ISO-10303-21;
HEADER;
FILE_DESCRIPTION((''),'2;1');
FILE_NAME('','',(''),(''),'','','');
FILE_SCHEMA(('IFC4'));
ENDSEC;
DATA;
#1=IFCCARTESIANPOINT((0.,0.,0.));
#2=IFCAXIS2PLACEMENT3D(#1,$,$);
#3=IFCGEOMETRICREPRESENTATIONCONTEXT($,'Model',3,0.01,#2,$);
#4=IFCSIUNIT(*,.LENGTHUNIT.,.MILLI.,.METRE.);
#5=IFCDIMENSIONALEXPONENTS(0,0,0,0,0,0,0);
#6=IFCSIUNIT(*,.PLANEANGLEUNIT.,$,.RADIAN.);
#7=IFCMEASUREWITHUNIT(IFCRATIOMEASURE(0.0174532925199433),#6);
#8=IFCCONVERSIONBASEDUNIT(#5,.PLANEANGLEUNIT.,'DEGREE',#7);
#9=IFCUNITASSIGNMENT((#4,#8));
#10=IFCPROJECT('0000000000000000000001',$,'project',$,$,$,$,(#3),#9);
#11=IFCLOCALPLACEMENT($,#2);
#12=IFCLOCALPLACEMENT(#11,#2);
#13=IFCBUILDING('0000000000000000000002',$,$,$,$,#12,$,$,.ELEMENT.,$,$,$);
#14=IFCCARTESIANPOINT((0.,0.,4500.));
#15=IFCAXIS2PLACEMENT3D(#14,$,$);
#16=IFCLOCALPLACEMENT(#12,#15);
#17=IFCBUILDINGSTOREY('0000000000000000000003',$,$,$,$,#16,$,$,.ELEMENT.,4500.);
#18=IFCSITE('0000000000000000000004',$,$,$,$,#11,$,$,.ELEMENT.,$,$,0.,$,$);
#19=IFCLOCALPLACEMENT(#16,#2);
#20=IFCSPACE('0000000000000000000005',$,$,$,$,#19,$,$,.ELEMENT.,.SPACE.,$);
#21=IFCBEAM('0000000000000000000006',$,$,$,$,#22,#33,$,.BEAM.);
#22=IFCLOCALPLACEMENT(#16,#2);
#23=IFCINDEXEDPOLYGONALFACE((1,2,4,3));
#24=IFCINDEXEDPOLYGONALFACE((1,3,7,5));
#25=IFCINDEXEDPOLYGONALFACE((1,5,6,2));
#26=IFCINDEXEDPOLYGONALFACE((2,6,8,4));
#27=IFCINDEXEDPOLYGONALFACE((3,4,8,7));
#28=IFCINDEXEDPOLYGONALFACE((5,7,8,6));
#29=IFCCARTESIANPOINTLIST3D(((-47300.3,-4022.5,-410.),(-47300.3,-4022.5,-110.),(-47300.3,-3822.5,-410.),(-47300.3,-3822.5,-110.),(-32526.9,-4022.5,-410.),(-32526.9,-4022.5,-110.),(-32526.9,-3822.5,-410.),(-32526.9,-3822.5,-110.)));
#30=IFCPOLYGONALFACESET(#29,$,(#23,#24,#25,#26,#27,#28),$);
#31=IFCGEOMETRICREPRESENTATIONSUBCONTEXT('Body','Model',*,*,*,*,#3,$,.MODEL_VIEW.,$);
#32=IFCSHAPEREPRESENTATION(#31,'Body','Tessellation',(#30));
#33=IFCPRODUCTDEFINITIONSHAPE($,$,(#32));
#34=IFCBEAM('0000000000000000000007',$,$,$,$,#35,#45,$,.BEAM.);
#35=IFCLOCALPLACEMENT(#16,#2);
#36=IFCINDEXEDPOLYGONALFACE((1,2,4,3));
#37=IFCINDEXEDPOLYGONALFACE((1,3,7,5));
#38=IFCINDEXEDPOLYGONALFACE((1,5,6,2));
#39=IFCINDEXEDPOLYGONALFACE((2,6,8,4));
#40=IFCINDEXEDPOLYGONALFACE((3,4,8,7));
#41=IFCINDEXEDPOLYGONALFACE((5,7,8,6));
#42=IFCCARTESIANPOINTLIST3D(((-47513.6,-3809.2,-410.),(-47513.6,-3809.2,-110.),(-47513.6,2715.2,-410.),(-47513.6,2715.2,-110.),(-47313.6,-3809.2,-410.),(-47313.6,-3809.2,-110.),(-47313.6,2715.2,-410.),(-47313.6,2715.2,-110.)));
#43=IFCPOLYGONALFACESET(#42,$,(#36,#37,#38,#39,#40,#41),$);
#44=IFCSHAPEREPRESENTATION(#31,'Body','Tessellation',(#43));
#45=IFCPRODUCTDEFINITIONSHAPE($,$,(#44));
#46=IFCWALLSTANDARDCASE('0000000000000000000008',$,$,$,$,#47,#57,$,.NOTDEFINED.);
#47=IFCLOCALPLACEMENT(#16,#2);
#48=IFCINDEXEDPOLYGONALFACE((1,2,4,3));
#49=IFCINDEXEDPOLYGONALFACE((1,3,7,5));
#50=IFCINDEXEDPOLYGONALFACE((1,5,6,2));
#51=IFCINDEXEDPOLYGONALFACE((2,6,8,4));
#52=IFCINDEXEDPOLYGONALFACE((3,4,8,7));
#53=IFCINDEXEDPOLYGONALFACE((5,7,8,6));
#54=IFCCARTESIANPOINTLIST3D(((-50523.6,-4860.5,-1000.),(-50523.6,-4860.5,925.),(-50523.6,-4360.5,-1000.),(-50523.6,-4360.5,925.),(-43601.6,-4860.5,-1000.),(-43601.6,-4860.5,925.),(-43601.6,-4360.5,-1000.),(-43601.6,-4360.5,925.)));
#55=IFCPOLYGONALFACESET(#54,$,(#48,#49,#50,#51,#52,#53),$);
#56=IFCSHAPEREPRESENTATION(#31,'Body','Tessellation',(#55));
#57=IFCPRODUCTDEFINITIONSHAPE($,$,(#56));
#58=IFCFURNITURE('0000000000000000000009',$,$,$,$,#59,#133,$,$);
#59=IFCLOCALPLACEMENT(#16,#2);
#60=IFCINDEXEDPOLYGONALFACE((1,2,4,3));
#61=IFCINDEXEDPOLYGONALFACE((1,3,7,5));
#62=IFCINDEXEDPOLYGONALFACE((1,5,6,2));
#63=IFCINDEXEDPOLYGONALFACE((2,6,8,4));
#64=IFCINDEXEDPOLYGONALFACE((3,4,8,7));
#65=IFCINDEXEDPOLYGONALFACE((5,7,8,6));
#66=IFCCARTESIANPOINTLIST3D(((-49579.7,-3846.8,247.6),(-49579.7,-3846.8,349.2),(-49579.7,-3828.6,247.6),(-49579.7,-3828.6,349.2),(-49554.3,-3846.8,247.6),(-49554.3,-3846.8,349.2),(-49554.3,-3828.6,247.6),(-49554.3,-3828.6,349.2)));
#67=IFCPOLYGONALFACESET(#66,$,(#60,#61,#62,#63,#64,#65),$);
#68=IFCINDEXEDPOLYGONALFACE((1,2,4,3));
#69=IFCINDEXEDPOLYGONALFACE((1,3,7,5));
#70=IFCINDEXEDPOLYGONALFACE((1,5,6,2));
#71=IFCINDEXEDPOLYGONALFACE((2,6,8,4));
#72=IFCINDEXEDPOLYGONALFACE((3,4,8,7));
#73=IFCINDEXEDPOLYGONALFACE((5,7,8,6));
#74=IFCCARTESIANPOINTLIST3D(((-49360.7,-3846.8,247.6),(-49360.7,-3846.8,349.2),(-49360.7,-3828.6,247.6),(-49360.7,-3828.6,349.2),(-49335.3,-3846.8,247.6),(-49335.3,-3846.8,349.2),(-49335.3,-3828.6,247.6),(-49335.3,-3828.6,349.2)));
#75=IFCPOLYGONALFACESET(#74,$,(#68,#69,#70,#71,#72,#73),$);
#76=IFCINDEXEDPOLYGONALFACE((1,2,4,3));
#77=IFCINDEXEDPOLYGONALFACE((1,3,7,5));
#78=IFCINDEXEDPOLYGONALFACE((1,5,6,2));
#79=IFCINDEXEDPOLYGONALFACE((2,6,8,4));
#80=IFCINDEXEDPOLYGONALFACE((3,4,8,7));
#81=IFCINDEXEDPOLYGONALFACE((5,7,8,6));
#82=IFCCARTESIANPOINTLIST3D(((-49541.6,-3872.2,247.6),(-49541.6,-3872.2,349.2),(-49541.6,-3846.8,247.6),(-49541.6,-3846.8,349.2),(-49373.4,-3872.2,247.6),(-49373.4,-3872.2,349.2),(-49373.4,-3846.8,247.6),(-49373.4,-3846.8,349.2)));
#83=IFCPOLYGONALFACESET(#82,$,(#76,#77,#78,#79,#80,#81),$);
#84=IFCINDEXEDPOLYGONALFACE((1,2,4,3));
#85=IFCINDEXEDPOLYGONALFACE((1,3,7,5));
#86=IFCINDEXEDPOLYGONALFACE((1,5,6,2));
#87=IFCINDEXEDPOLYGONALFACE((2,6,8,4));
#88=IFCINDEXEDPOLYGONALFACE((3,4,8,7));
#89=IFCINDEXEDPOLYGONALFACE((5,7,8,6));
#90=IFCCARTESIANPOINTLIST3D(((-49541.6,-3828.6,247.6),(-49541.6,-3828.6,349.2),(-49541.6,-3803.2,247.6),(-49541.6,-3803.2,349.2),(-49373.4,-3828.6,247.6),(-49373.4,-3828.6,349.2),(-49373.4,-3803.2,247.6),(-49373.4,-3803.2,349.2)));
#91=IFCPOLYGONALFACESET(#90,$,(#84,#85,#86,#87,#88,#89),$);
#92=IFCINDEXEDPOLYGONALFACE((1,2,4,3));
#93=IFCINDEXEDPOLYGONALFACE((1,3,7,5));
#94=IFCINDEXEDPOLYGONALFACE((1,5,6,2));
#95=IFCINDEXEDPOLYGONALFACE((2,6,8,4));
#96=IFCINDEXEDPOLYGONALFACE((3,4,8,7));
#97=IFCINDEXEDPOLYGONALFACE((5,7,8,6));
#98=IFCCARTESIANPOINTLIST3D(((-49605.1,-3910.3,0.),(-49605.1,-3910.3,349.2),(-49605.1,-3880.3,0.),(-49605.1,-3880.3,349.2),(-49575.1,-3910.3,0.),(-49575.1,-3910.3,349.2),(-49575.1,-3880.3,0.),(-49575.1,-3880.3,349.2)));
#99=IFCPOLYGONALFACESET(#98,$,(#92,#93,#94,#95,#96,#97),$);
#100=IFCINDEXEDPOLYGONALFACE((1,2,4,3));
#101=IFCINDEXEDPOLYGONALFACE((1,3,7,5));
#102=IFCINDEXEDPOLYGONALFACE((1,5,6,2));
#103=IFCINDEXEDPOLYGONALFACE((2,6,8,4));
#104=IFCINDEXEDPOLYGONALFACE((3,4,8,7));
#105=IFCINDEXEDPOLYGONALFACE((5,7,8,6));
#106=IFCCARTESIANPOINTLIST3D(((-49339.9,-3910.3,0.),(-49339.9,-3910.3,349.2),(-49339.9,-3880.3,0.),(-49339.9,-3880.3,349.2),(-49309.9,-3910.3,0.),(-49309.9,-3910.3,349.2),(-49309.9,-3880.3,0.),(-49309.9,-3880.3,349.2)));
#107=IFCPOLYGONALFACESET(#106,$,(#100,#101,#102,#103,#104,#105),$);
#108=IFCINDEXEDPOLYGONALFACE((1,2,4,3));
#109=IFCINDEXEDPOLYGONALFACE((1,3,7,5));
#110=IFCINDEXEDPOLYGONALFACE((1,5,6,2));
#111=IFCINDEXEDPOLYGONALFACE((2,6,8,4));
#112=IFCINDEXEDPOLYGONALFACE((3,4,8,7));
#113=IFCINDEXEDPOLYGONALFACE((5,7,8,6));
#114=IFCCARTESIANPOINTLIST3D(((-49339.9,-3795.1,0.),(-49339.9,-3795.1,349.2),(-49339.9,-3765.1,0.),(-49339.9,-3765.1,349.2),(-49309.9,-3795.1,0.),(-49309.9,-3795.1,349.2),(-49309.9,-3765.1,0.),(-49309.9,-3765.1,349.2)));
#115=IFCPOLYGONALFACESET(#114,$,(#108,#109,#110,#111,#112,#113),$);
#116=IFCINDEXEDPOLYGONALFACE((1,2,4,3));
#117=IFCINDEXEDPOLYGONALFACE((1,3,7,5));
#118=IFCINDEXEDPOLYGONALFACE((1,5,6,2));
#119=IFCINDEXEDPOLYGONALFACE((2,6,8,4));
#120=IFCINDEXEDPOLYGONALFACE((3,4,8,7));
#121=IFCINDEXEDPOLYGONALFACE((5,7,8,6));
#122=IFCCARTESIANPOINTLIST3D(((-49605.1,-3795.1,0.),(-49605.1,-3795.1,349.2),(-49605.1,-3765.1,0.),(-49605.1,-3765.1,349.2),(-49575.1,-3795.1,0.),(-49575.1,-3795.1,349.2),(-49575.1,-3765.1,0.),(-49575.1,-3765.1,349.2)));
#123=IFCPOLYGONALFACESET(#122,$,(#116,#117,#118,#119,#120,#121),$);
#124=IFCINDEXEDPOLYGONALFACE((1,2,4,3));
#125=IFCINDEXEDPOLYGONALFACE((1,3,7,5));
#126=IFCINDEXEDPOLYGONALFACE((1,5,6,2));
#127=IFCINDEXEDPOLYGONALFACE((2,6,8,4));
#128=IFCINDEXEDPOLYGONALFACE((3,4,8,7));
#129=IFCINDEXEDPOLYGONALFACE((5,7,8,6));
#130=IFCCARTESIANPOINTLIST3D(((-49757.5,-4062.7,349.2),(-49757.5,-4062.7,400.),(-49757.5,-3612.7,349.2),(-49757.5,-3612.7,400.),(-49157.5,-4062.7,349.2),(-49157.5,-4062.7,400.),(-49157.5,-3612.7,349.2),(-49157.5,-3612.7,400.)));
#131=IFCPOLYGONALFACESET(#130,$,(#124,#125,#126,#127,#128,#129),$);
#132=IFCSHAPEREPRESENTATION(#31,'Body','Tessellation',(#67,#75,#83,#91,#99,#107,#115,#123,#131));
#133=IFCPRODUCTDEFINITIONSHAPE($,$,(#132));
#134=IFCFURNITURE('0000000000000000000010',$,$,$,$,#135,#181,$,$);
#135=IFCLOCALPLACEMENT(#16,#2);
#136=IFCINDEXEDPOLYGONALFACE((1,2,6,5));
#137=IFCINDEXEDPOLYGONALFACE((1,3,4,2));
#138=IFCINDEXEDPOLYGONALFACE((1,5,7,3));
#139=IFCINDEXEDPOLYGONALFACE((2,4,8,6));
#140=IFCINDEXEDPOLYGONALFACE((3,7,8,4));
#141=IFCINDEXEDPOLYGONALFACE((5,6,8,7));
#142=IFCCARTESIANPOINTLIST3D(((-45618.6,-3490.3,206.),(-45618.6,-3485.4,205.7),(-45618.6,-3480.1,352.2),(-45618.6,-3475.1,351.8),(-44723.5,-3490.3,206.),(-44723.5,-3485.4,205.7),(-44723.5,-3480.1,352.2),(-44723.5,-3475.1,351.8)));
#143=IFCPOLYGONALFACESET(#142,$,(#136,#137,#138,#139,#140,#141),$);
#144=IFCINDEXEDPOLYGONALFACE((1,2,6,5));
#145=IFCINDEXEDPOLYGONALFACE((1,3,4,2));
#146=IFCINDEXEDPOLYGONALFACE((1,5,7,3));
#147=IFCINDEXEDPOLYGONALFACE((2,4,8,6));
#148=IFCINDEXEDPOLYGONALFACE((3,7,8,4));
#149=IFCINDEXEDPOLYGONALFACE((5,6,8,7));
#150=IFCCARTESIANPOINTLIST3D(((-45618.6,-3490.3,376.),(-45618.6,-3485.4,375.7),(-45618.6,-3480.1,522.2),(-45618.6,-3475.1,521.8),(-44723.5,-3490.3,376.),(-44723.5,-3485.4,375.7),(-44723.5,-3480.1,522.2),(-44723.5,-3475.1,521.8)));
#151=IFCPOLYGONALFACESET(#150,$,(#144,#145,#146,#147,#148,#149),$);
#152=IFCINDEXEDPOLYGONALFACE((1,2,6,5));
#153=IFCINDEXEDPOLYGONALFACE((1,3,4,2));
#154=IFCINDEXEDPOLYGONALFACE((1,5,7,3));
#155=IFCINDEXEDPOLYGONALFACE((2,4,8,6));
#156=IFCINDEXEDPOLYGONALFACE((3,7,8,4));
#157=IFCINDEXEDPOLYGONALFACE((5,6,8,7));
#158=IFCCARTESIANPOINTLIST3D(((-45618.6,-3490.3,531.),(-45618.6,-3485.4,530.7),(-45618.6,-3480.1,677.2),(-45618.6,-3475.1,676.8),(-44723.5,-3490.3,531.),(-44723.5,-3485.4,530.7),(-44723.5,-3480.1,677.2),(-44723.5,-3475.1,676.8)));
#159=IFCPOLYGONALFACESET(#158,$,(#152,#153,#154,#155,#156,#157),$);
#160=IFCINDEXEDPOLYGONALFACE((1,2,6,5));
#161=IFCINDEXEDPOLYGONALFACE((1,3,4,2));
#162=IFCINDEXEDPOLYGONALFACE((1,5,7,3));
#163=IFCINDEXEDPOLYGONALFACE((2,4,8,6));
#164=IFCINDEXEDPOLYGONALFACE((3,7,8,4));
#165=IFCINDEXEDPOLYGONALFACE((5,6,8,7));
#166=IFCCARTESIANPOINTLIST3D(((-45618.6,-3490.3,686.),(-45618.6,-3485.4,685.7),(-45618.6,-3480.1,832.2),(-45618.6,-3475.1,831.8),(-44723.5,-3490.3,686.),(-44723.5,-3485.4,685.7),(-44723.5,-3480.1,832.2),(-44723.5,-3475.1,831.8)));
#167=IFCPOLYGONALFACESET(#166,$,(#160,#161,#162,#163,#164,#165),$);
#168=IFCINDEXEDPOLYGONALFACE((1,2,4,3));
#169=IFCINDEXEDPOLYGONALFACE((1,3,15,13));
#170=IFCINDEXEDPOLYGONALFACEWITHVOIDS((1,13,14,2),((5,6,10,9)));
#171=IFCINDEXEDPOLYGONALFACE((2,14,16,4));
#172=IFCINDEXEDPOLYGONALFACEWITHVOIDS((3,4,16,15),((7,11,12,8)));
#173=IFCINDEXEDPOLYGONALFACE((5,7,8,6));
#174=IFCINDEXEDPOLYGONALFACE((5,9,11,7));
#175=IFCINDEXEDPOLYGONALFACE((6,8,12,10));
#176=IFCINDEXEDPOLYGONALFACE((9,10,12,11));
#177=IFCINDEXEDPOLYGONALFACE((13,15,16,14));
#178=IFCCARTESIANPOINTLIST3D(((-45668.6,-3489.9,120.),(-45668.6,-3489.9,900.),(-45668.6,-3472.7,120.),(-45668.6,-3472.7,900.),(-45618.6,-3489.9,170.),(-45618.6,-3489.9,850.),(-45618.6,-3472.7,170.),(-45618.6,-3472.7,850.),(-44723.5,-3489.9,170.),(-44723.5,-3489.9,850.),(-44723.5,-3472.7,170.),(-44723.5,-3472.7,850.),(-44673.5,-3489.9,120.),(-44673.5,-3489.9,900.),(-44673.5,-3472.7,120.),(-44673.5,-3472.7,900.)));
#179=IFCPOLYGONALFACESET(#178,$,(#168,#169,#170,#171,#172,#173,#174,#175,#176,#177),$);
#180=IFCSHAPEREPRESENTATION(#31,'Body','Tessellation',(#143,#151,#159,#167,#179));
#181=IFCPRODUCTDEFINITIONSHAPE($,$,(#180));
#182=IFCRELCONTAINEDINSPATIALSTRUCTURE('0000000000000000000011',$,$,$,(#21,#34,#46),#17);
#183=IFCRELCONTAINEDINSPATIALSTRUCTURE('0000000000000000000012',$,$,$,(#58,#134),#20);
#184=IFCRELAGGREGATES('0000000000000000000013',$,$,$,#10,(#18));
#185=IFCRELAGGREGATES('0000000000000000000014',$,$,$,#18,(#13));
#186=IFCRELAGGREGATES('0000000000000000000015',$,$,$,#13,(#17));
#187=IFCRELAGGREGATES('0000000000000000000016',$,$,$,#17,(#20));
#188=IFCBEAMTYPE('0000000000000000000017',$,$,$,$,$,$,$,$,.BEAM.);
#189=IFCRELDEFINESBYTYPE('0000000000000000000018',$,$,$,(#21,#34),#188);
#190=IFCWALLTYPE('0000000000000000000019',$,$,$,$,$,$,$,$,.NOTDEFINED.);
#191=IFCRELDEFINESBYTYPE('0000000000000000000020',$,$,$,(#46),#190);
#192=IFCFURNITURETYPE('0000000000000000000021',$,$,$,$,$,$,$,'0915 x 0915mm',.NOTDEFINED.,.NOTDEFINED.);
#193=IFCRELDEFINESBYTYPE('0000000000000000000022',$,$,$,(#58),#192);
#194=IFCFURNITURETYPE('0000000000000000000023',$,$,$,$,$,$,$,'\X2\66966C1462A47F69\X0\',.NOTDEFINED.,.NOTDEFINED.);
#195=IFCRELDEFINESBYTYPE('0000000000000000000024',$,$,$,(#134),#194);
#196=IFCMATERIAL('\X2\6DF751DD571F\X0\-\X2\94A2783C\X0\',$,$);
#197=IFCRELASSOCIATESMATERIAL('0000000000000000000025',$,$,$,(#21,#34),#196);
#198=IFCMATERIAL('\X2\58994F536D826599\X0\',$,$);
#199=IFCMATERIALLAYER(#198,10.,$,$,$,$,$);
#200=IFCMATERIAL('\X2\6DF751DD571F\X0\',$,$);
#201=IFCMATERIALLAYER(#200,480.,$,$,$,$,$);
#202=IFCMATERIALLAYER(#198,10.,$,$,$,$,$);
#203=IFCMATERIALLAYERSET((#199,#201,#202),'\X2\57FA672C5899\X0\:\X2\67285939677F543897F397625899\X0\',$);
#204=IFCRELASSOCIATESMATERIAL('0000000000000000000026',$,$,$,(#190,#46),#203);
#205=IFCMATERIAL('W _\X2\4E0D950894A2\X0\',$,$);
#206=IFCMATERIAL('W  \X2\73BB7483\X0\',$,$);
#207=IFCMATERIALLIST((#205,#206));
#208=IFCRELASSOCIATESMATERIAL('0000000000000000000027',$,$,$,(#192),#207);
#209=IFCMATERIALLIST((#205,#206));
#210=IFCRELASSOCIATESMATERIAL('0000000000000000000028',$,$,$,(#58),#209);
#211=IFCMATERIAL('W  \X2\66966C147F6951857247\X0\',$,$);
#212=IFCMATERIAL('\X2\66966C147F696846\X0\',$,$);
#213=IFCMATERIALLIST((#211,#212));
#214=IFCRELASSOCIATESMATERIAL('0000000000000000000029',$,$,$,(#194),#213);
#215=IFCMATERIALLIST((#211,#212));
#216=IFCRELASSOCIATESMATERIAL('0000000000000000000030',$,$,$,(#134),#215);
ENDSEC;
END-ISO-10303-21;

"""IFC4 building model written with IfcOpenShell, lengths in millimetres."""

from ifc_helpers import new_model, entity, si_unit, converted_unit, frame, frame_2d, origin, origin_2d_with_axis, place, context, subcontext, project, spatial, polyline, rectangle, outline, extrude, source, transform, mapped, material, material_list, layer, layer_set, layer_usage, type_object, type_shapes, element, save


model = new_model("IFC4")

# Units and contexts
model_context = context("Model", 3, precision=0.01, world=origin())
body_context = subcontext(model_context, "Body", "Model", "MODEL_VIEW")
ifc_project = project(units=[si_unit("LENGTHUNIT", "METRE", prefix="MILLI"), converted_unit("PLANEANGLEUNIT", "DEGREE", entity("IfcRatioMeasure", 0.0174532925199433), si_unit("PLANEANGLEUNIT", "RADIAN"), dimensions=[0, 0, 0, 0, 0, 0, 0])], contexts=[model_context])

# Site, building, storey
site_placement = place(None, origin())
site = spatial("IfcSite", under=ifc_project, at=site_placement, CompositionType="ELEMENT", RefElevation=0.0)
building_placement = place(site_placement, origin())
building = spatial("IfcBuilding", under=site, at=building_placement, CompositionType="ELEMENT")
storey_placement = place(building_placement, frame((0.0, 0.0, 4500.0)))
storey = spatial("IfcBuildingStorey", under=building, at=storey_placement, CompositionType="ELEMENT", Elevation=4500.0)

# Beams
ifc_material_1 = material(Name="混凝土-钢砼")
beam_type = type_object("IfcBeamType", PredefinedType="BEAM")
beam_1_placement = place(storey_placement, frame((-47413.6, -3922.5, -110.0)))
element("IfcBeam", 1, at=beam_1_placement, inside=storey, type_object=beam_type, material=ifc_material_1, PredefinedType="BEAM", context=body_context, shape_type="SweptSolid", body=[
    extrude(rectangle(XDim=300.0, YDim=200.0, at=frame_2d((0.0, 0.0), x_axis=(1.0, 0.0))), frame((113.3, 0.0, -150.0), z_axis=(1.0, 0.0, 0.0), x_axis=(0.0, 0.0, -1.0)), (0.0, 0.0, 1.0), 14773.4),
])
beam_2_placement = place(storey_placement, frame((-47413.6, -3922.5, -110.0), z_axis=(0.0, 0.0, 1.0), x_axis=(0.0, 1.0, 0.0)))
element("IfcBeam", 2, at=beam_2_placement, inside=storey, type_object=beam_type, material=ifc_material_1, PredefinedType="BEAM", context=body_context, shape_type="SweptSolid", body=[
    extrude(rectangle(XDim=300.0, YDim=200.0, at=origin_2d_with_axis()), frame((113.3, 0.0, -150.0), z_axis=(1.0, 0.0, 0.0), x_axis=(0.0, 0.0, -1.0)), (0.0, 0.0, 1.0), 6524.4),
])

# Wall
ifc_material_2 = material(Name="墙体涂料")
ifc_layer_1 = layer(ifc_material_2, 10.0)
ifc_material_3 = material(Name="混凝土")
ifc_layer_2 = layer(ifc_material_3, 480.0)
ifc_layer_3 = layer(ifc_material_2, 10.0)
ifc_layer_set = layer_set([ifc_layer_1, ifc_layer_2, ifc_layer_3], Name="基本墙:木夹板吸音面墙")
ifc_layer_usage = layer_usage(ifc_layer_set, "AXIS2", "NEGATIVE", 250.0)
wall_type = type_object("IfcWallType", PredefinedType="NOTDEFINED", material=ifc_layer_set)
wall_placement = place(storey_placement, frame((-43601.6, -4610.5, -1000.0), z_axis=(0.0, 0.0, 1.0), x_axis=(-1.0, 0.0, 0.0)))
element("IfcWallStandardCase", 3, at=wall_placement, inside=storey, type_object=wall_type, material=ifc_layer_usage, PredefinedType="NOTDEFINED", context=body_context, shape_type="SweptSolid", body=[
    extrude(rectangle(XDim=6922.0, YDim=500.0, at=frame_2d((3461.0, 0.0), x_axis=(-1.0, 0.0))), origin(), (0.0, 0.0, 1.0), 1925.0),
])

# Shared definitions
space_placement = place(storey_placement, origin())
space = spatial("IfcSpace", under=storey, at=space_placement, CompositionType="ELEMENT", PredefinedType="SPACE")

# Furniture
ifc_material_4 = material(Name="W _不锈钢")
ifc_material_5 = material(Name="W  玻璃")
ifc_material_list_1 = material_list([ifc_material_4, ifc_material_5])
ifc_material_list_2 = material_list([ifc_material_4, ifc_material_5])
furniture_type_1 = type_object("IfcFurnitureType", ElementType="0915 x 0915mm", AssemblyPlace="NOTDEFINED", PredefinedType="NOTDEFINED", material=ifc_material_list_2)
shared_shape_1 = source(origin(), body_context, "Body", "SweptSolid", [
    extrude(rectangle(XDim=25.4, YDim=18.2, at=origin_2d_with_axis()), frame((109.5, 0.0, 247.6)), (0.0, 0.0, 1.0), 101.6),
    extrude(rectangle(XDim=18.2, YDim=25.4, at=origin_2d_with_axis()), frame((-109.5, 0.0, 247.6), z_axis=(0.0, 0.0, 1.0), x_axis=(0.0, 1.0, 0.0)), (0.0, 0.0, 1.0), 101.6),
    extrude(rectangle(XDim=168.2, YDim=25.4, at=frame_2d((0.0, 0.0), x_axis=(1.0, 0.0))), frame((0.0, 21.8, 247.6), z_axis=(0.0, 0.0, 1.0), x_axis=(-1.0, 0.0, 0.0)), (0.0, 0.0, 1.0), 101.6),
    extrude(rectangle(XDim=25.4, YDim=168.2, at=origin_2d_with_axis()), frame((0.0, -21.8, 247.6), z_axis=(0.0, 0.0, 1.0), x_axis=(0.0, 1.0, 0.0)), (0.0, 0.0, 1.0), 101.6),
    extrude(rectangle(XDim=30.0, YDim=30.0, at=origin_2d_with_axis()), frame((132.6, 57.6, 0.0), z_axis=(0.0, 0.0, 1.0), x_axis=(0.0, -1.0, 0.0)), (0.0, 0.0, 1.0), 349.2),
    extrude(rectangle(XDim=30.0, YDim=30.0, at=frame_2d((0.0, 0.0), x_axis=(1.0, 0.0))), frame((-132.6, 57.6, 0.0), z_axis=(0.0, 0.0, 1.0), x_axis=(-1.0, 0.0, 0.0)), (0.0, 0.0, 1.0), 349.2),
    extrude(rectangle(XDim=30.0, YDim=30.0, at=frame_2d((0.0, 0.0), x_axis=(1.0, 0.0))), frame((-132.6, -57.6, 0.0), z_axis=(0.0, 0.0, 1.0), x_axis=(0.0, 1.0, 0.0)), (0.0, 0.0, 1.0), 349.2),
    extrude(rectangle(XDim=30.0, YDim=30.0, at=frame_2d((0.0, 0.0), x_axis=(1.0, 0.0))), frame((132.6, -57.6, 0.0)), (0.0, 0.0, 1.0), 349.2),
    extrude(rectangle(XDim=600.0, YDim=450.0, at=origin_2d_with_axis()), frame((0.0, 0.0, 349.2), z_axis=(0.0, 0.0, 1.0), x_axis=(-1.0, 0.0, 0.0)), (0.0, 0.0, 1.0), 50.8),
])
type_shapes(furniture_type_1, [shared_shape_1])
furniture_1_placement = place(space_placement, frame((-49457.5, -3837.7, 0.0), z_axis=(0.0, 0.0, 1.0), x_axis=(-1.0, 0.0, 0.0)))
element("IfcFurniture", 4, at=furniture_1_placement, inside=space, type_object=furniture_type_1, material=ifc_material_list_1, context=body_context, shape_type="MappedRepresentation", body=[
    mapped(shared_shape_1, transform((0.0, 0.0, 0.0), scale=1.0)),
])
ifc_material_6 = material(Name="W  暖气罩内片")
ifc_material_7 = material(Name="暖气罩框")
ifc_material_list_3 = material_list([ifc_material_6, ifc_material_7])
ifc_material_list_4 = material_list([ifc_material_6, ifc_material_7])
furniture_type_2 = type_object("IfcFurnitureType", ElementType="暖气护罩", AssemblyPlace="NOTDEFINED", PredefinedType="NOTDEFINED", material=ifc_material_list_4)
shared_shape_2 = source(origin(), body_context, "Body", "SweptSolid", [
    extrude(rectangle(XDim=146.5, YDim=5.0, at=frame_2d((0.0, 0.0), x_axis=(0.0, 1.0))), frame((50.0, 7.6, 158.9), z_axis=(1.0, 0.0, 0.0), x_axis=(0.0, -0.997564, 0.069756)), (0.0, 0.0, 1.0), 895.1),
    extrude(rectangle(XDim=146.5, YDim=5.0, at=frame_2d((0.0, 0.0), x_axis=(0.0, 1.0))), frame((50.0, 7.6, 328.9), z_axis=(1.0, 0.0, 0.0), x_axis=(0.0, -0.997564, 0.069756)), (0.0, 0.0, 1.0), 895.1),
    extrude(rectangle(XDim=146.5, YDim=5.0, at=frame_2d((0.0, 0.0), x_axis=(0.0, 1.0))), frame((50.0, 7.6, 483.9), z_axis=(1.0, 0.0, 0.0), x_axis=(0.0, -0.997564, 0.069756)), (0.0, 0.0, 1.0), 895.1),
    extrude(rectangle(XDim=146.5, YDim=5.0, at=frame_2d((0.0, 0.0), x_axis=(0.0, 1.0))), frame((50.0, 7.6, 638.9), z_axis=(1.0, 0.0, 0.0), x_axis=(0.0, -0.997564, 0.069756)), (0.0, 0.0, 1.0), 895.1),
    extrude(outline(polyline([(-497.5, -390.0), (497.5, -390.0), (497.5, 390.0), (-497.5, 390.0), (-497.5, -390.0)]), holes=[polyline([(-447.5, -340.0), (-447.5, 340.0), (447.5, 340.0), (447.5, -340.0), (-447.5, -340.0)])]), frame((497.5, 0.5, 390.0), z_axis=(0.0, 1.0, 0.0), x_axis=(1.0, 0.0, 0.0)), (0.0, 0.0, 1.0), 17.2),
])
type_shapes(furniture_type_2, [shared_shape_2])
furniture_2_placement = place(space_placement, frame((-45668.6, -3490.3, 120.0)))
element("IfcFurniture", 5, at=furniture_2_placement, inside=space, type_object=furniture_type_2, material=ifc_material_list_3, context=body_context, shape_type="MappedRepresentation", body=[
    mapped(shared_shape_2, transform((0.0, 0.0, 0.0), scale=1.0)),
])

save(model, "model.ifc")
